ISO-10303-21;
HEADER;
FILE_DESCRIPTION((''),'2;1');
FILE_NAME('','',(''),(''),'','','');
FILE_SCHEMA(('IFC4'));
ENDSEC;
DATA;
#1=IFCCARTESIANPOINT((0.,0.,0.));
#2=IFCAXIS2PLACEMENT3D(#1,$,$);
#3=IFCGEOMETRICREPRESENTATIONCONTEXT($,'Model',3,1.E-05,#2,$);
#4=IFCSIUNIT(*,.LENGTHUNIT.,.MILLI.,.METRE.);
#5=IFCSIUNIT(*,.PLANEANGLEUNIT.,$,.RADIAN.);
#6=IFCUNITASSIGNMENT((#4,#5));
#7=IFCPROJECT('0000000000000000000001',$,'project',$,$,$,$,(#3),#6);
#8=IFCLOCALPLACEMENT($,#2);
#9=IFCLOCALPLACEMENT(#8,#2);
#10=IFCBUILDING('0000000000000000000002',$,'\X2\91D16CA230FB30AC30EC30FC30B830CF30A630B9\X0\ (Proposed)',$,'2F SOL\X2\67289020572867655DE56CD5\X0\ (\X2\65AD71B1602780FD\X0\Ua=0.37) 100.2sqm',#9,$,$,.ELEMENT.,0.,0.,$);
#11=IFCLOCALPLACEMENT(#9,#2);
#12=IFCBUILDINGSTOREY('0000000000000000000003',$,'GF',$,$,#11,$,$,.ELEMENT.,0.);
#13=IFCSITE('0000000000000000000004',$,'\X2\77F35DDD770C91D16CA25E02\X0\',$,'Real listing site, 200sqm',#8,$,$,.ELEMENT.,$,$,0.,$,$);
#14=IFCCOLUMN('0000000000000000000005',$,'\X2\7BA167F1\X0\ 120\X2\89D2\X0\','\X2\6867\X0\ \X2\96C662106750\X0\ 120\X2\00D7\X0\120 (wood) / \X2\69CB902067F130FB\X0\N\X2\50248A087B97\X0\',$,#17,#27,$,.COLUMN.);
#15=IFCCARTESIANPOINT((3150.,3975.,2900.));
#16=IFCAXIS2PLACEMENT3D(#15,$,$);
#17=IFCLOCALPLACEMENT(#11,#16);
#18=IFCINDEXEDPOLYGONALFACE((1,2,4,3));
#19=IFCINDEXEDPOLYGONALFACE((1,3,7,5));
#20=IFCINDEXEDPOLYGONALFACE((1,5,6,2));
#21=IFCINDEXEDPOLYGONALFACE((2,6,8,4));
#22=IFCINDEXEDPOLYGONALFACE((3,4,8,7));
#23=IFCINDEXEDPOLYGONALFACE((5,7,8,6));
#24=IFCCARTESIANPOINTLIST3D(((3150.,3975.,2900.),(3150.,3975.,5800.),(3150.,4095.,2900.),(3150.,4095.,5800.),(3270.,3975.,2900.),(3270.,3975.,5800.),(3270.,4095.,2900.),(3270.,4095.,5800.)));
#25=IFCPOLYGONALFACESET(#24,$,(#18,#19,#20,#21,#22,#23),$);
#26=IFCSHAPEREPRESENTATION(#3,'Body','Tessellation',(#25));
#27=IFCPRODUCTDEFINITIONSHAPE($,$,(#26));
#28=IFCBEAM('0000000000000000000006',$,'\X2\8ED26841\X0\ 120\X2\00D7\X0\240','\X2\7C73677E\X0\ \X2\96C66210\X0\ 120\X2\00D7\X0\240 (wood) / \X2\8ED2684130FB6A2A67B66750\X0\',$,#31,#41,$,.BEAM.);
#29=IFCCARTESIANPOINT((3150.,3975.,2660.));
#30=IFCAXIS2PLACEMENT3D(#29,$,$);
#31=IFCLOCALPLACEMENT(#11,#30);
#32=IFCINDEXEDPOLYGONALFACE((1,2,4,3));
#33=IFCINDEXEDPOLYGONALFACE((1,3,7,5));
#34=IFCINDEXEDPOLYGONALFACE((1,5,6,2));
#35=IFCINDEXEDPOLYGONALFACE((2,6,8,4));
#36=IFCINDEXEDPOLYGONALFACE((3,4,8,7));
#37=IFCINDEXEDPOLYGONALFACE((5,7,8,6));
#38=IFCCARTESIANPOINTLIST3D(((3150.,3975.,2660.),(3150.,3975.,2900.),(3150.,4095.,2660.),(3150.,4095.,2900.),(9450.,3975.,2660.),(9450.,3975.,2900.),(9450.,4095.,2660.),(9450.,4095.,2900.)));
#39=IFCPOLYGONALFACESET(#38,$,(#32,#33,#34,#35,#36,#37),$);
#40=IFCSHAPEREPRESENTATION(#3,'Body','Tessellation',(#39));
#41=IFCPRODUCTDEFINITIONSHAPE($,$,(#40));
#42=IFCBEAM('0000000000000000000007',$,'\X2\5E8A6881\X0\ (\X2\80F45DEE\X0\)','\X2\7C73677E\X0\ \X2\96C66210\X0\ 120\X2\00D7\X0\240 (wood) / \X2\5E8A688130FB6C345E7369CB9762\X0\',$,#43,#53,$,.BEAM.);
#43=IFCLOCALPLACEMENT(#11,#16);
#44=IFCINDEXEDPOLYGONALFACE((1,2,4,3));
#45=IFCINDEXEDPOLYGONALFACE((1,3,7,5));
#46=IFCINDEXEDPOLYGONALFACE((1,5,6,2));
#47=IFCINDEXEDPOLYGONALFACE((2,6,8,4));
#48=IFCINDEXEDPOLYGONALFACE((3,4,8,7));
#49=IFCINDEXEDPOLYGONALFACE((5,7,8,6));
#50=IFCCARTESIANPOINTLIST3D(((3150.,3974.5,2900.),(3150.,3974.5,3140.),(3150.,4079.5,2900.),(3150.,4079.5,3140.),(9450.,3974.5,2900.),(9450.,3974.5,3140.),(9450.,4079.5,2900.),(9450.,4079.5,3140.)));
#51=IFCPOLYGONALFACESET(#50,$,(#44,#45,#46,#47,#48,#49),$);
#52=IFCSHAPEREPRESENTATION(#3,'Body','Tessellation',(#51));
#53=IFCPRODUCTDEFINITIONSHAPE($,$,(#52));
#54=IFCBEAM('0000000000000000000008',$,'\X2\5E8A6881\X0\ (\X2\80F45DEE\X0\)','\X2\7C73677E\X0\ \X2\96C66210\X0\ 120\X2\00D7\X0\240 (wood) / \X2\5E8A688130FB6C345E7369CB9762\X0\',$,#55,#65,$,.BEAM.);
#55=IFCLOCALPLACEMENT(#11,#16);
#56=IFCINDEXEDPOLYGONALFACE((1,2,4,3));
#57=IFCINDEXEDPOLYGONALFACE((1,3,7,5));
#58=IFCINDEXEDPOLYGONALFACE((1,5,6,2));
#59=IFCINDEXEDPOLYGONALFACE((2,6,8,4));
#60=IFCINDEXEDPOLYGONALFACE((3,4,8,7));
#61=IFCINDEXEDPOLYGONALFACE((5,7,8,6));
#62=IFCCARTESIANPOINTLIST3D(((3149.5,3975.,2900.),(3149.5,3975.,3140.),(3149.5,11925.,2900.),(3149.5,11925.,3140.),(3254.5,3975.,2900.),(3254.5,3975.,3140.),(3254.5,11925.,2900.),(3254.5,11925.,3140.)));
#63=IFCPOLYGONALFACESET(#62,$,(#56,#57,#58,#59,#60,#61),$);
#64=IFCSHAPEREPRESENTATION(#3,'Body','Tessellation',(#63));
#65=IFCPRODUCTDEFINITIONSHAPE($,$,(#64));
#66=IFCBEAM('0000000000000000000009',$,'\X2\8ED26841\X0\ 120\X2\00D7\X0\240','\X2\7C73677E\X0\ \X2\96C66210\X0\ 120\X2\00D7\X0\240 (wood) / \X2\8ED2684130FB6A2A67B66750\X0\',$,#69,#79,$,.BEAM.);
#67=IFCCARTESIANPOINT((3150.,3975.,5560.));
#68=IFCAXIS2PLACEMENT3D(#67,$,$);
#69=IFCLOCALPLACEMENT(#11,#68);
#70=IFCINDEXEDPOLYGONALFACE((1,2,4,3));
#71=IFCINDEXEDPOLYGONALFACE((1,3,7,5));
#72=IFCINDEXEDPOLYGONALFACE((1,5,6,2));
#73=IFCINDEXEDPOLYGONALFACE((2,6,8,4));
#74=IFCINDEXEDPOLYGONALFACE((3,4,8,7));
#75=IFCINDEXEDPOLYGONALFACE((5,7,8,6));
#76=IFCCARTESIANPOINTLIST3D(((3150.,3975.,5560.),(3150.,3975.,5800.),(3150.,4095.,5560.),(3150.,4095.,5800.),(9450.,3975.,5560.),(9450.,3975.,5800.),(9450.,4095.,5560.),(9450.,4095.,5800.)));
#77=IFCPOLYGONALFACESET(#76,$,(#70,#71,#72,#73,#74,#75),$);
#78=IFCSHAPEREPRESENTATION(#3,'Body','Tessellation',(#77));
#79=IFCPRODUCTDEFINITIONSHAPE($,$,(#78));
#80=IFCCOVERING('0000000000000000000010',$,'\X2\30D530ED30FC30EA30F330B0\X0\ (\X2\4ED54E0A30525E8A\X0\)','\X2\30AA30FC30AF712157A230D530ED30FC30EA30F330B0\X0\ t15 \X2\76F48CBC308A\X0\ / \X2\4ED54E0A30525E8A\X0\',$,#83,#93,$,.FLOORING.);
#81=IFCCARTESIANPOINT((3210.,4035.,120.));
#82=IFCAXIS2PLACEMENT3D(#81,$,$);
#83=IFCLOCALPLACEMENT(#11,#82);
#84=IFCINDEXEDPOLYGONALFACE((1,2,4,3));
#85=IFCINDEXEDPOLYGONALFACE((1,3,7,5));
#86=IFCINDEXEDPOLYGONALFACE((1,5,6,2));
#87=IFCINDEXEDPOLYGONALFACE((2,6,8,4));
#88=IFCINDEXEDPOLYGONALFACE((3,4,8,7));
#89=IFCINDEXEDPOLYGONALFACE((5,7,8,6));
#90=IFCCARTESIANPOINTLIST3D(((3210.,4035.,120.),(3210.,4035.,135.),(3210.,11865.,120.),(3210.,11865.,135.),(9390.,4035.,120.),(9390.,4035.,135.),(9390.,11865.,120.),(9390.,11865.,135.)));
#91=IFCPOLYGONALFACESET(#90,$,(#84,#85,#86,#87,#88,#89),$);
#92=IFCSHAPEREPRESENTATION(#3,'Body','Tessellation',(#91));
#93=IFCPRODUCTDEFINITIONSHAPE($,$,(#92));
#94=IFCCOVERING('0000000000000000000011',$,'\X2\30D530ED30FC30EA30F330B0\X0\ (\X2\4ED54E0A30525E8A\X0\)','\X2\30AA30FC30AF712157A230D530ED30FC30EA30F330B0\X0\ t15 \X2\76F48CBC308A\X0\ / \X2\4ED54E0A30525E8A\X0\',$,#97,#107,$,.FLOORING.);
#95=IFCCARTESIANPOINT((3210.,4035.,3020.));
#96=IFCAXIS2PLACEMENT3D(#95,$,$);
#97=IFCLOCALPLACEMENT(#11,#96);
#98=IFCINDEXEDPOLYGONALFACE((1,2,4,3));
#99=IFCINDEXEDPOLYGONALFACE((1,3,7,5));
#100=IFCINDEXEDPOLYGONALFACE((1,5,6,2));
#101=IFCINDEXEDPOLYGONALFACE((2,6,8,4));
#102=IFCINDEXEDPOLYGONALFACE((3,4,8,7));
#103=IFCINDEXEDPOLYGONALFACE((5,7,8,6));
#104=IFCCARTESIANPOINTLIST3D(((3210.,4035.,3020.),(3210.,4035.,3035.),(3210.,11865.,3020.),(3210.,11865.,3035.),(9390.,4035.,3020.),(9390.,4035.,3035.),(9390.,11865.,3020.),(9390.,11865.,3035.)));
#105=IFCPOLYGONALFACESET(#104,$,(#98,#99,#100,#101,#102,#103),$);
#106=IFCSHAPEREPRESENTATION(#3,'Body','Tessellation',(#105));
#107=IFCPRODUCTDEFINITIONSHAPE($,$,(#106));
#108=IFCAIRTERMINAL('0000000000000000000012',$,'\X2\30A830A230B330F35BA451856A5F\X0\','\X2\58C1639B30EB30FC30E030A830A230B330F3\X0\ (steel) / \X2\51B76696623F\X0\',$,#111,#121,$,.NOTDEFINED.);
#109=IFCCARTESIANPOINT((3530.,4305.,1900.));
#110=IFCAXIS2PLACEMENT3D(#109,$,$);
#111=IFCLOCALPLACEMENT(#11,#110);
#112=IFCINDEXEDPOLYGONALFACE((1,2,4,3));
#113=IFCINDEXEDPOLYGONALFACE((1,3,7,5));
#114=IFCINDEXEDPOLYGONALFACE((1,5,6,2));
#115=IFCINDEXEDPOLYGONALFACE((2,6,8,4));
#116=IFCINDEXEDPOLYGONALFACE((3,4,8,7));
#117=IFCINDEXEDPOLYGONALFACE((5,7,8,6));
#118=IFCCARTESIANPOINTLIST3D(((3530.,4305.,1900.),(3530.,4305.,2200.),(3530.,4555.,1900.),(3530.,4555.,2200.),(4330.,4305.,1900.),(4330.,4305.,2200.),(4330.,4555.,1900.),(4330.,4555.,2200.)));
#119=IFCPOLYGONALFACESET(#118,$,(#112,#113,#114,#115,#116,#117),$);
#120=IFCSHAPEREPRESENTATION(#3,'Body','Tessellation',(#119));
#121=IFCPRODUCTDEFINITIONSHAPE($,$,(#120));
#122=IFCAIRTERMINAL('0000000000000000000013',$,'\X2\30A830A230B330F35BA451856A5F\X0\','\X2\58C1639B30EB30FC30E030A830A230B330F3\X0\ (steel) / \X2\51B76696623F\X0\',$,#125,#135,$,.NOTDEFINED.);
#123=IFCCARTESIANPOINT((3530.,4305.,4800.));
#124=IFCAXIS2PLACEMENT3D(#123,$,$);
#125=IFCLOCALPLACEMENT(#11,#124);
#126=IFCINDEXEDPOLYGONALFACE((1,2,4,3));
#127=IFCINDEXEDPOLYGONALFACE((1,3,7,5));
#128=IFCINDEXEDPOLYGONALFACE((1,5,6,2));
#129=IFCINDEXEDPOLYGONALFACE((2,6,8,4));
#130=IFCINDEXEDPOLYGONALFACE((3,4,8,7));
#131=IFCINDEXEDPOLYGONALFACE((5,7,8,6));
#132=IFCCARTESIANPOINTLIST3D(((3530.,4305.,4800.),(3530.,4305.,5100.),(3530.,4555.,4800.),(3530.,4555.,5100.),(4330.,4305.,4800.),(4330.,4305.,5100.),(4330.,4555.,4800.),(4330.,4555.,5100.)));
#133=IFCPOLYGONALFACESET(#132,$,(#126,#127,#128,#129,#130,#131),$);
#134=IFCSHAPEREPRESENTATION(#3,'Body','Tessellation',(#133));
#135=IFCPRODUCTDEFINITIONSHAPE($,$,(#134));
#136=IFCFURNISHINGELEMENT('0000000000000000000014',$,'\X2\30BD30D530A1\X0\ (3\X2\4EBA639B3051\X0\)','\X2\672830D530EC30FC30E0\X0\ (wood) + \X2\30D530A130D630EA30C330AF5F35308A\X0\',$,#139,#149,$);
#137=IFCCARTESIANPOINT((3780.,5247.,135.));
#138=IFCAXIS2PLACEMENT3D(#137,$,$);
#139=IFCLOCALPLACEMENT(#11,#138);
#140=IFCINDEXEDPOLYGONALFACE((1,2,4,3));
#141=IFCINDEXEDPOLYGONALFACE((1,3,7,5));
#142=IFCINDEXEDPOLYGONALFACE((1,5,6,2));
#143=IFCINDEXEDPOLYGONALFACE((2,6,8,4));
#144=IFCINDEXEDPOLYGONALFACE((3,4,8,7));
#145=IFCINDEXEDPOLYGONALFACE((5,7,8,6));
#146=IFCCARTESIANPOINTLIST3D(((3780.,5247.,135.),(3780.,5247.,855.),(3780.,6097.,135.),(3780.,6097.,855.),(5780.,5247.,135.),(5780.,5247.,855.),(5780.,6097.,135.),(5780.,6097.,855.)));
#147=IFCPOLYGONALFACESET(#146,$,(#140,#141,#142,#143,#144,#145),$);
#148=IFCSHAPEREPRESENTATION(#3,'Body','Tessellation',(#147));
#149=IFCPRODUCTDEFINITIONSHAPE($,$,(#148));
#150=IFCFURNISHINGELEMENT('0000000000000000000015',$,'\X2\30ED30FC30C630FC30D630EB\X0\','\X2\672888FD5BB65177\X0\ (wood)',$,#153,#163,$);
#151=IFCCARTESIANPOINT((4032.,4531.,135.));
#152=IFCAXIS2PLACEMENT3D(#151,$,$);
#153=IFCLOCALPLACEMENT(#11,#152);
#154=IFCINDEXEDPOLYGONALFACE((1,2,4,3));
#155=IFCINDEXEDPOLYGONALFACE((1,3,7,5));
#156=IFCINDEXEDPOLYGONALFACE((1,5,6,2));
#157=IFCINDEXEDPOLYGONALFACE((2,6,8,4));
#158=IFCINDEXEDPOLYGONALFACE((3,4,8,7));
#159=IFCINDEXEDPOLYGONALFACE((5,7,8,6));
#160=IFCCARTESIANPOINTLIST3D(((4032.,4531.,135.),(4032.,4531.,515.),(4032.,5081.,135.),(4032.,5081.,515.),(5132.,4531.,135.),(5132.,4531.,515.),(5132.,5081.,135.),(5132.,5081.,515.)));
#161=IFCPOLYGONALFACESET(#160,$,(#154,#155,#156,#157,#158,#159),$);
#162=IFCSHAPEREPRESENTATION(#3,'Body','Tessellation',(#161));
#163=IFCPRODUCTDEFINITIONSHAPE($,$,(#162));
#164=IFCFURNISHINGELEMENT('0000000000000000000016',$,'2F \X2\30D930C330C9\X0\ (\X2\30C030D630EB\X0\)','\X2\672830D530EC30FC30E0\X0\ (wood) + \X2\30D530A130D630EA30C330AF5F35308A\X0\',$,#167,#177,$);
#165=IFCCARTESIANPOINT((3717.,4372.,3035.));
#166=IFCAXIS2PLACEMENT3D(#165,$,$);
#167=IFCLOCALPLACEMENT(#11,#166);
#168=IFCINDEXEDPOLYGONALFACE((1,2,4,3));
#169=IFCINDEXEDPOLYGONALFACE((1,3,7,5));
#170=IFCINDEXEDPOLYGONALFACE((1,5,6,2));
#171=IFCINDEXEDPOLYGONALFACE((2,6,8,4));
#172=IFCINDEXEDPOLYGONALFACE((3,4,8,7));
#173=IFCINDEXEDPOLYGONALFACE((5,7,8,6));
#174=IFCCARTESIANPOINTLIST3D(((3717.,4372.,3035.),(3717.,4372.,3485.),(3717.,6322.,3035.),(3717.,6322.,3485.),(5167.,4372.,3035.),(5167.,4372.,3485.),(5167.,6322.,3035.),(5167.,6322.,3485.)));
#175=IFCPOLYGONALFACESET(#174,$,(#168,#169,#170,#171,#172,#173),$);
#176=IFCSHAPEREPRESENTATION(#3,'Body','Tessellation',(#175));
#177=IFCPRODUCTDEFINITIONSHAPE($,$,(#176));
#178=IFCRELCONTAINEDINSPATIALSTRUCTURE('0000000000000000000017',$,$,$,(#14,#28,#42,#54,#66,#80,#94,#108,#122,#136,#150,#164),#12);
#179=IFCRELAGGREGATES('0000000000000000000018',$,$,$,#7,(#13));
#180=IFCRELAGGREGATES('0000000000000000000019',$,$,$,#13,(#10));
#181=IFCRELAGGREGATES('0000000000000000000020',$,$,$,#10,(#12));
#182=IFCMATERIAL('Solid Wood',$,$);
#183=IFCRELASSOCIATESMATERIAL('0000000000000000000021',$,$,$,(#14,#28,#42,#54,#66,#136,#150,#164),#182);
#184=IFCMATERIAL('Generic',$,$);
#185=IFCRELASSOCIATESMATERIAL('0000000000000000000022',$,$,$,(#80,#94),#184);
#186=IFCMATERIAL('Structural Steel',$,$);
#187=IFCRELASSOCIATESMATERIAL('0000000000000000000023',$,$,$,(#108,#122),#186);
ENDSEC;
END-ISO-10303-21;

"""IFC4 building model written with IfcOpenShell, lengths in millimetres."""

from ifc_helpers import new_model, si_unit, frame, frame_2d, origin, place, context, project, spatial, rectangle, extrude, material, element, save


model = new_model("IFC4")

# Units and contexts
model_context = context("Model", 3, precision=1e-05, world=origin())
ifc_project = project(units=[si_unit("LENGTHUNIT", "METRE", prefix="MILLI"), si_unit("PLANEANGLEUNIT", "RADIAN")], contexts=[model_context])

# Site, building, storey
site_placement = place(None, origin())
site = spatial("IfcSite", under=ifc_project, at=site_placement, Name="石川県金沢市", ObjectType="Real listing site, 200sqm", CompositionType="ELEMENT", RefElevation=0.0)
building_placement = place(site_placement, origin())
building = spatial("IfcBuilding", under=site, at=building_placement, Name="金沢・ガレージハウス (Proposed)", ObjectType="2F SOL木造在来工法 (断熱性能Ua=0.37) 100.2sqm", CompositionType="ELEMENT", ElevationOfRefHeight=0.0, ElevationOfTerrain=0.0)
storey_placement = place(building_placement, origin())
storey = spatial("IfcBuildingStorey", under=building, at=storey_placement, Name="GF", CompositionType="ELEMENT", Elevation=0.0)

# Column
ifc_material_1 = material(Name="Solid Wood")
column_1_placement = place(storey_placement, frame((3150.0, 3975.0, 2900.0)))
element("IfcColumn", 1, at=column_1_placement, inside=storey, material=ifc_material_1, Name="管柱 120角", Description="桧 集成材 120×120 (wood) / 構造柱・N値計算", PredefinedType="COLUMN", context=model_context, shape_type="SweptSolid", body=[
    extrude(rectangle(XDim=120.0, YDim=120.0, at=frame_2d((60.0, 60.0))), frame((3150.0, 3975.0, 2900.0)), (0.0, 0.0, 1.0), 2900.0),
])

# Beams
beam_1_placement = place(storey_placement, frame((3150.0, 3975.0, 2660.0)))
element("IfcBeam", 2, at=beam_1_placement, inside=storey, material=ifc_material_1, Name="軒桁 120×240", Description="米松 集成 120×240 (wood) / 軒桁・横架材", PredefinedType="BEAM", context=model_context, shape_type="SweptSolid", body=[
    extrude(rectangle(XDim=6300.0, YDim=120.0, at=frame_2d((3150.0, 60.0))), frame((3150.0, 3975.0, 2660.0)), (0.0, 0.0, 1.0), 240.0),
])
beam_2_placement = place(storey_placement, frame((3150.0, 3975.0, 2900.0)))
element("IfcBeam", 3, at=beam_2_placement, inside=storey, material=ifc_material_1, Name="床梁 (胴差)", Description="米松 集成 120×240 (wood) / 床梁・水平構面", PredefinedType="BEAM", context=model_context, shape_type="SweptSolid", body=[
    extrude(rectangle(XDim=6300.0, YDim=105.0, at=frame_2d((3150.0, 52.0))), frame((3150.0, 3975.0, 2900.0)), (0.0, 0.0, 1.0), 240.0),
])
beam_3_placement = place(storey_placement, frame((3150.0, 3975.0, 2900.0)))
element("IfcBeam", 4, at=beam_3_placement, inside=storey, material=ifc_material_1, Name="床梁 (胴差)", Description="米松 集成 120×240 (wood) / 床梁・水平構面", PredefinedType="BEAM", context=model_context, shape_type="SweptSolid", body=[
    extrude(rectangle(XDim=105.0, YDim=7950.0, at=frame_2d((52.0, 3975.0))), frame((3150.0, 3975.0, 2900.0)), (0.0, 0.0, 1.0), 240.0),
])
beam_4_placement = place(storey_placement, frame((3150.0, 3975.0, 5560.0)))
element("IfcBeam", 5, at=beam_4_placement, inside=storey, material=ifc_material_1, Name="軒桁 120×240", Description="米松 集成 120×240 (wood) / 軒桁・横架材", PredefinedType="BEAM", context=model_context, shape_type="SweptSolid", body=[
    extrude(rectangle(XDim=6300.0, YDim=120.0, at=frame_2d((3150.0, 60.0))), frame((3150.0, 3975.0, 5560.0)), (0.0, 0.0, 1.0), 240.0),
])

# Coverings
ifc_material_2 = material(Name="Generic")
covering_1_placement = place(storey_placement, frame((3210.0, 4035.0, 120.0)))
element("IfcCovering", 6, at=covering_1_placement, inside=storey, material=ifc_material_2, Name="フローリング (仕上げ床)", Description="オーク無垢フローリング t15 直貼り / 仕上げ床", PredefinedType="FLOORING", context=model_context, shape_type="SweptSolid", body=[
    extrude(rectangle(XDim=6180.0, YDim=7830.0, at=frame_2d((3090.0, 3915.0))), frame((3210.0, 4035.0, 120.0)), (0.0, 0.0, 1.0), 15.0),
])
covering_2_placement = place(storey_placement, frame((3210.0, 4035.0, 3020.0)))
element("IfcCovering", 7, at=covering_2_placement, inside=storey, material=ifc_material_2, Name="フローリング (仕上げ床)", Description="オーク無垢フローリング t15 直貼り / 仕上げ床", PredefinedType="FLOORING", context=model_context, shape_type="SweptSolid", body=[
    extrude(rectangle(XDim=6180.0, YDim=7830.0, at=frame_2d((3090.0, 3915.0))), frame((3210.0, 4035.0, 3020.0)), (0.0, 0.0, 1.0), 15.0),
])

# Air terminals
ifc_material_3 = material(Name="Structural Steel")
air_terminal_1_placement = place(storey_placement, frame((3530.0, 4305.0, 1900.0)))
element("IfcAirTerminal", 8, at=air_terminal_1_placement, inside=storey, material=ifc_material_3, Name="エアコン室内機", Description="壁掛ルームエアコン (steel) / 冷暖房", PredefinedType="NOTDEFINED", context=model_context, shape_type="SweptSolid", body=[
    extrude(rectangle(XDim=800.0, YDim=250.0, at=frame_2d((400.0, 125.0))), frame((3530.0, 4305.0, 1900.0)), (0.0, 0.0, 1.0), 300.0),
])
air_terminal_2_placement = place(storey_placement, frame((3530.0, 4305.0, 4800.0)))
element("IfcAirTerminal", 9, at=air_terminal_2_placement, inside=storey, material=ifc_material_3, Name="エアコン室内機", Description="壁掛ルームエアコン (steel) / 冷暖房", PredefinedType="NOTDEFINED", context=model_context, shape_type="SweptSolid", body=[
    extrude(rectangle(XDim=800.0, YDim=250.0, at=frame_2d((400.0, 125.0))), frame((3530.0, 4305.0, 4800.0)), (0.0, 0.0, 1.0), 300.0),
])

# Furnishing elements
furnishing_1_placement = place(storey_placement, frame((3780.0, 5247.0, 135.0)))
element("IfcFurnishingElement", 10, at=furnishing_1_placement, inside=storey, material=ifc_material_1, Name="ソファ (3人掛け)", Description="木フレーム (wood) + ファブリック張り", context=model_context, shape_type="SweptSolid", body=[
    extrude(rectangle(XDim=2000.0, YDim=850.0, at=frame_2d((1000.0, 425.0))), frame((3780.0, 5247.0, 135.0)), (0.0, 0.0, 1.0), 720.0),
])
furnishing_2_placement = place(storey_placement, frame((4032.0, 4531.0, 135.0)))
element("IfcFurnishingElement", 11, at=furnishing_2_placement, inside=storey, material=ifc_material_1, Name="ローテーブル", Description="木製家具 (wood)", context=model_context, shape_type="SweptSolid", body=[
    extrude(rectangle(XDim=1100.0, YDim=550.0, at=frame_2d((550.0, 275.0))), frame((4032.0, 4531.0, 135.0)), (0.0, 0.0, 1.0), 380.0),
])
furnishing_3_placement = place(storey_placement, frame((3717.0, 4372.0, 3035.0)))
element("IfcFurnishingElement", 12, at=furnishing_3_placement, inside=storey, material=ifc_material_1, Name="2F ベッド (ダブル)", Description="木フレーム (wood) + ファブリック張り", context=model_context, shape_type="SweptSolid", body=[
    extrude(rectangle(XDim=1450.0, YDim=1950.0, at=frame_2d((725.0, 975.0))), frame((3717.0, 4372.0, 3035.0)), (0.0, 0.0, 1.0), 450.0),
])

save(model, "model.ifc")
